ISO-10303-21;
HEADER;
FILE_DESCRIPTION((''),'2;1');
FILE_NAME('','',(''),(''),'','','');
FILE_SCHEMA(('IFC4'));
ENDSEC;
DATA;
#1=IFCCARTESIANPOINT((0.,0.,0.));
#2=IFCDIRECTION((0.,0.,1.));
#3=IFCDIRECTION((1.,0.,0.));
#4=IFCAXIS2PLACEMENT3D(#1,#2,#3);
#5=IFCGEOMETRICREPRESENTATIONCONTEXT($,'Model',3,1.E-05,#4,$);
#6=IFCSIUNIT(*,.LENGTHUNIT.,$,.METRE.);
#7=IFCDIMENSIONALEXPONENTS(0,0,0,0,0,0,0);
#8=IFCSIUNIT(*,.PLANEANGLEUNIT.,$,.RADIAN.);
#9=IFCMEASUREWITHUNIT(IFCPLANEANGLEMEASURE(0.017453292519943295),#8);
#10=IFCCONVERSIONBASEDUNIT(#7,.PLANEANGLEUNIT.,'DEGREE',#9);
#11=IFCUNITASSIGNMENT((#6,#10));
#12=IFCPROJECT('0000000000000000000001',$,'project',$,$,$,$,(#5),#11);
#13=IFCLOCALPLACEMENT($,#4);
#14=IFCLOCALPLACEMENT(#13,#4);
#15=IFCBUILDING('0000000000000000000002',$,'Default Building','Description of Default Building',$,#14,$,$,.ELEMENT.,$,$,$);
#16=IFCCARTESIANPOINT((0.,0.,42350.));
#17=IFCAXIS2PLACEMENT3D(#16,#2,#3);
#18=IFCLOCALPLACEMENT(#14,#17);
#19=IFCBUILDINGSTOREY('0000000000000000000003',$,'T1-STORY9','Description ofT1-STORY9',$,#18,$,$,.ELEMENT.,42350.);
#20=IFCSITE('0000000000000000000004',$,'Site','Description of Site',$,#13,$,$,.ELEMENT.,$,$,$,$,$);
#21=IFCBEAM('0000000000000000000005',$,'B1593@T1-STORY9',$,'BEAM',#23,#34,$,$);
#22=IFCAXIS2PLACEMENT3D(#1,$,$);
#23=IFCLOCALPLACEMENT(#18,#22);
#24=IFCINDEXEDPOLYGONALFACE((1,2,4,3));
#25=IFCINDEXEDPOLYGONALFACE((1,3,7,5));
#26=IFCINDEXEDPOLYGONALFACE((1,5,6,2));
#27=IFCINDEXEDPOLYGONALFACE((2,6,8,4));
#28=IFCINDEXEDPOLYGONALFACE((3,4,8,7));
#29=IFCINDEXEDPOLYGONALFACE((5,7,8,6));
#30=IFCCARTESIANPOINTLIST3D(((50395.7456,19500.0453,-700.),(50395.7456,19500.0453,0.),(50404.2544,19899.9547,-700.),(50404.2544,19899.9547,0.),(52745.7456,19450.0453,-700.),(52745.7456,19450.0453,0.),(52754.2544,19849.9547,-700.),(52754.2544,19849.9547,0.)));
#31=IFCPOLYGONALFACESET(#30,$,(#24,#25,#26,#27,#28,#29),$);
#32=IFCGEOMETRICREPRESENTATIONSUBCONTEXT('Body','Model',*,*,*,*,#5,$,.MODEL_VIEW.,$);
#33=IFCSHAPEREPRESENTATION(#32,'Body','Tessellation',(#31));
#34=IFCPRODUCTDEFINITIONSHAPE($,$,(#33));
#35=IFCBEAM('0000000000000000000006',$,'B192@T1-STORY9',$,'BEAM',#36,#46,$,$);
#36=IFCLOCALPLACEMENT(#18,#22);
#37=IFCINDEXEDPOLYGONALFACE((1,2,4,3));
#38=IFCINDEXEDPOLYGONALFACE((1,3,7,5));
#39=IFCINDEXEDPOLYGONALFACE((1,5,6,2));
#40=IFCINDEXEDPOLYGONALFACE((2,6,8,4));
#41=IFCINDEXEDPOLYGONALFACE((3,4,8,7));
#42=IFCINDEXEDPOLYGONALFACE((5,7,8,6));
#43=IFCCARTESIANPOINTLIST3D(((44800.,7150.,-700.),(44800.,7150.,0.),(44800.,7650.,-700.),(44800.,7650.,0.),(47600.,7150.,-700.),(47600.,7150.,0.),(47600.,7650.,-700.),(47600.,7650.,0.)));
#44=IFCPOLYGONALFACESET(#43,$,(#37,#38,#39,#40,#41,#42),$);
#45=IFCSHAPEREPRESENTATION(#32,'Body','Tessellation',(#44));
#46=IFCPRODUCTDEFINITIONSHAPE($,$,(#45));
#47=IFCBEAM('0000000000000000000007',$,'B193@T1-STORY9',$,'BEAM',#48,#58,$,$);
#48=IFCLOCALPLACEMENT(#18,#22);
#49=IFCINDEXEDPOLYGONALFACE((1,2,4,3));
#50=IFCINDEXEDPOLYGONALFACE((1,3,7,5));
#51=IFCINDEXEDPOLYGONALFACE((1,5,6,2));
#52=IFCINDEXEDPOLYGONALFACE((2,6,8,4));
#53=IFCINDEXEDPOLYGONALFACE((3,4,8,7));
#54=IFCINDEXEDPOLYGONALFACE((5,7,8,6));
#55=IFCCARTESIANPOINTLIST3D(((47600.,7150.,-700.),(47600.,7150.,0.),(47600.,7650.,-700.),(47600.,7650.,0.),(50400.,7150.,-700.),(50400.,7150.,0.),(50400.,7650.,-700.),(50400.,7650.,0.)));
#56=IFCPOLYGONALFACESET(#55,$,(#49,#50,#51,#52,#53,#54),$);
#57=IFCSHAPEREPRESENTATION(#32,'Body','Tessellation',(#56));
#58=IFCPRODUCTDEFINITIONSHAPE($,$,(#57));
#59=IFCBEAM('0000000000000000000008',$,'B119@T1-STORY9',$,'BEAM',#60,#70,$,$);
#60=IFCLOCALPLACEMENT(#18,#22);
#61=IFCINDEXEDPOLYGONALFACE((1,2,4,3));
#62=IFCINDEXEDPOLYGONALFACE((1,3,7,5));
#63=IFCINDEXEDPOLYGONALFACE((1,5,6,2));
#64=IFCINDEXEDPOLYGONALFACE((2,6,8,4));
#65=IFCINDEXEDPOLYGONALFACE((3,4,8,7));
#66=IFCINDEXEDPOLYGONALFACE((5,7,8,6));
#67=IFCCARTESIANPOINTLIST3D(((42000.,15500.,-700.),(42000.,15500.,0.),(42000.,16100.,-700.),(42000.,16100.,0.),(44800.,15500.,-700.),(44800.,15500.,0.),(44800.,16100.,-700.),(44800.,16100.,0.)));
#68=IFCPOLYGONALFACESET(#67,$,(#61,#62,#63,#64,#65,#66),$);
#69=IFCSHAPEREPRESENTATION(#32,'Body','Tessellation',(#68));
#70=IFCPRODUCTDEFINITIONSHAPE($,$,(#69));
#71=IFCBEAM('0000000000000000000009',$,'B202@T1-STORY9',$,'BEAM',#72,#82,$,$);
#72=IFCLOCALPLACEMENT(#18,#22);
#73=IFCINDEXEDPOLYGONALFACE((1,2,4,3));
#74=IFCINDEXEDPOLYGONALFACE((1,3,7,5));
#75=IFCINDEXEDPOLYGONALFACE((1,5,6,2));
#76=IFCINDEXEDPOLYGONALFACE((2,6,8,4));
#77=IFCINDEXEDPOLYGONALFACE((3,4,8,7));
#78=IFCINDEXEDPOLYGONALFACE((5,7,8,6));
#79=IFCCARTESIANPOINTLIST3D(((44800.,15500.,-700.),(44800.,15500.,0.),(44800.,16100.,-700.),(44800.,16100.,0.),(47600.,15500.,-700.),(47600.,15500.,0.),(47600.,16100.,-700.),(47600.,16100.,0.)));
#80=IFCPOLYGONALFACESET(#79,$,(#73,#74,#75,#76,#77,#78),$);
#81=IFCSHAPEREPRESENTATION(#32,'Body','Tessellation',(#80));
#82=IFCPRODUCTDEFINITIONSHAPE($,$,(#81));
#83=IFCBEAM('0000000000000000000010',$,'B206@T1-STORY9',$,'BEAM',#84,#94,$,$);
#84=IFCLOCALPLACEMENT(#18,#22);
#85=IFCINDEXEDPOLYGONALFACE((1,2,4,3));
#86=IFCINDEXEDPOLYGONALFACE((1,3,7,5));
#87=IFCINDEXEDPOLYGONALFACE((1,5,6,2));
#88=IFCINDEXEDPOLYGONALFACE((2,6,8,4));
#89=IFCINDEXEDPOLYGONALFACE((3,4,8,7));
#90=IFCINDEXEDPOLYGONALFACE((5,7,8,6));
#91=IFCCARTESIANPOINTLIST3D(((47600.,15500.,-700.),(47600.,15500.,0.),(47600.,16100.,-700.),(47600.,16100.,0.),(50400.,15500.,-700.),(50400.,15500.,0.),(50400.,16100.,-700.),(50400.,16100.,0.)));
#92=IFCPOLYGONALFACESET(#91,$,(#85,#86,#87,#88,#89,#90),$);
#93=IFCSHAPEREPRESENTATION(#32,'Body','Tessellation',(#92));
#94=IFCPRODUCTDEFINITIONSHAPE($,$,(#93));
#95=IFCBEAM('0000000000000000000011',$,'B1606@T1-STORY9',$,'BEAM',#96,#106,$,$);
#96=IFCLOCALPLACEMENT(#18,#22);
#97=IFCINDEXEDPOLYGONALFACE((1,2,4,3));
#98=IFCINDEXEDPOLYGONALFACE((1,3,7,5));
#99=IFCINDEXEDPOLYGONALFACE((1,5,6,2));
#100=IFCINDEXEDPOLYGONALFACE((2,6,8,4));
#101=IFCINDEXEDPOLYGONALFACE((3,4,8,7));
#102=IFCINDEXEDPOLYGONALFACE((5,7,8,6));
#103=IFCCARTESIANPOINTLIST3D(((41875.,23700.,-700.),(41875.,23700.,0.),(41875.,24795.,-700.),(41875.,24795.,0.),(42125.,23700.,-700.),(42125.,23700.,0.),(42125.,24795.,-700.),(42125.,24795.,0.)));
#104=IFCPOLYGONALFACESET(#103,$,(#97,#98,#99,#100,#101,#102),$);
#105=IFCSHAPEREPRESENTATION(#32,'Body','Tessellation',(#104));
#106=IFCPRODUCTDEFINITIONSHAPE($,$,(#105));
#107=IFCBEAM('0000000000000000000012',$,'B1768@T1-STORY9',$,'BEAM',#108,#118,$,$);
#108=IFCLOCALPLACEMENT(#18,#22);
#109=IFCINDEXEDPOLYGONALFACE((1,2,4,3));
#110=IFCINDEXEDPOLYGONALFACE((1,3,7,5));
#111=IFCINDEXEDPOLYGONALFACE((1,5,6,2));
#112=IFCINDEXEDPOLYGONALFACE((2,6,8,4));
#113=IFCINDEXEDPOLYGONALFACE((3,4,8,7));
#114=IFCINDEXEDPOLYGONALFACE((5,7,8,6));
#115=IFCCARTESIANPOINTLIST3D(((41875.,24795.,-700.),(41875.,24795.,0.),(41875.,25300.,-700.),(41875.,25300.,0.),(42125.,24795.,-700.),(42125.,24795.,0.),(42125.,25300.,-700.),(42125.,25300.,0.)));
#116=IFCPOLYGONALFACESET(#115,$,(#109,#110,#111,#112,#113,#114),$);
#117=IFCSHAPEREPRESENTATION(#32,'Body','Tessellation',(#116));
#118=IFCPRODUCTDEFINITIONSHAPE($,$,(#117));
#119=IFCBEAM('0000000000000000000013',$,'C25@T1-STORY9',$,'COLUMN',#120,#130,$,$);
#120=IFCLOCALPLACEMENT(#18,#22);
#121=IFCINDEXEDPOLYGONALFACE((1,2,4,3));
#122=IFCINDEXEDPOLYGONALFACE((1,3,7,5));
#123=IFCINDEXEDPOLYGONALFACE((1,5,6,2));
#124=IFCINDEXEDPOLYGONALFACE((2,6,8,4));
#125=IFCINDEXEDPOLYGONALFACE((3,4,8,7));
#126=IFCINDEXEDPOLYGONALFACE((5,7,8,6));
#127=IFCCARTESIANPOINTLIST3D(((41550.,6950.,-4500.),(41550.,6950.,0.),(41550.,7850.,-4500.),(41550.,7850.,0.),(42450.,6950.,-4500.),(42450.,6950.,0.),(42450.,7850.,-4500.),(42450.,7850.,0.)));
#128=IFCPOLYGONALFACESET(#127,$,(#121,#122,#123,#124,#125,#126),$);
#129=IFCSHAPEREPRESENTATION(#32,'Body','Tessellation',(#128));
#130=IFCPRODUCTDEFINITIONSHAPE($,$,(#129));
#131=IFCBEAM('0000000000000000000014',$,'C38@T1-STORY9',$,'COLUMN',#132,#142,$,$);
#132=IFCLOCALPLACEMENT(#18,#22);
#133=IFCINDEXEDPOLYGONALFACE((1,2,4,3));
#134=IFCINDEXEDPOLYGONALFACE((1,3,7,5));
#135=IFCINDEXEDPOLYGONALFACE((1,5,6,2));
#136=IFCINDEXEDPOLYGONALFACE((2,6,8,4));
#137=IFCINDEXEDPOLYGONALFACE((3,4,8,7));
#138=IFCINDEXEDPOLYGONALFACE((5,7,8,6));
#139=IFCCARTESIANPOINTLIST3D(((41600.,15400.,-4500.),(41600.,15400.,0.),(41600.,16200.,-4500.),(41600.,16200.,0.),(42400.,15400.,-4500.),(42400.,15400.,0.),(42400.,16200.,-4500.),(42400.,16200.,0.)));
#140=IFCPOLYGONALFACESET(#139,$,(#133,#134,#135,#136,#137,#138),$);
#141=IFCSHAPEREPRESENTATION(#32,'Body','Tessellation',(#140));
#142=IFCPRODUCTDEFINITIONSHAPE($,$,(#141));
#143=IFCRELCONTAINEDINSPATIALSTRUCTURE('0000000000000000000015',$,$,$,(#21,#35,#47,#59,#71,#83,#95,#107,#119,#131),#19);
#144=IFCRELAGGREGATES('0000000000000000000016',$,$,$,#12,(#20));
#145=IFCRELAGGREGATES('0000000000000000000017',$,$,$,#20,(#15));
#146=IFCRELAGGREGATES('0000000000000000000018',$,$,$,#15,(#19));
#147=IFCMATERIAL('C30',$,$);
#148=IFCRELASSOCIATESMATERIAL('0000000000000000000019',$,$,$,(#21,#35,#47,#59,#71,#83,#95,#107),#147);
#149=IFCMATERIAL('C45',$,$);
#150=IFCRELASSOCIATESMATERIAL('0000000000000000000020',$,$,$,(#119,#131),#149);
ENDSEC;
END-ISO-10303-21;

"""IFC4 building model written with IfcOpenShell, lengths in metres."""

from ifc_helpers import new_model, entity, si_unit, converted_unit, frame, origin_with_axes, place, context, subcontext, project, spatial, rectangle, extrude, material, element, save


model = new_model("IFC4")

# Units and contexts
model_context = context("Model", 3, precision=1e-05, world=origin_with_axes())
body_context = subcontext(model_context, "Body", "Model", "MODEL_VIEW")
ifc_project = project(units=[si_unit("LENGTHUNIT", "METRE"), converted_unit("PLANEANGLEUNIT", "DEGREE", entity("IfcPlaneAngleMeasure", 0.017453292519943295), si_unit("PLANEANGLEUNIT", "RADIAN"), dimensions=[0, 0, 0, 0, 0, 0, 0])], contexts=[model_context])

# Site, building, storey
site_placement = place(None, origin_with_axes())
site = spatial("IfcSite", under=ifc_project, at=site_placement, Name="Site", Description="Description of Site", CompositionType="ELEMENT")
building_placement = place(site_placement, origin_with_axes())
building = spatial("IfcBuilding", under=site, at=building_placement, Name="Default Building", Description="Description of Default Building", CompositionType="ELEMENT")
storey_placement = place(building_placement, frame((0.0, 0.0, 42350.0), z_axis=(0.0, 0.0, 1.0), x_axis=(1.0, 0.0, 0.0)))
storey = spatial("IfcBuildingStorey", under=building, at=storey_placement, Name="T1-STORY9", Description="Description ofT1-STORY9", CompositionType="ELEMENT", Elevation=42350.0)

# Beams
ifc_material_1 = material(Name="C30")
beam_1_placement = place(storey_placement, frame((50400.0, 19700.0, -350.0), z_axis=(0.999774, -0.021272, 0.0), x_axis=(0.021272, 0.999774, 0.0)))
element("IfcBeam", 1, at=beam_1_placement, inside=storey, material=ifc_material_1, Name="B1593@T1-STORY9", ObjectType="BEAM", context=body_context, shape_type="SweptSolid", body=[
    extrude(rectangle(XDim=400.0, YDim=700.0), origin_with_axes(), (0.0, 0.0, 1.0), 2350.5319),
])
for number, where, z_axis, x_axis, name in (
    (2, (44800.0, 7400.0, -350.0), (1.0, 0.0, 0.0), (0.0, 1.0, 0.0), "B192@T1-STORY9"),
    (3, (47600.0, 7400.0, -350.0), (1.0, 0.0, 0.0), (0.0, 1.0, 0.0), "B193@T1-STORY9"),
):
    element("IfcBeam", number, at=place(storey_placement, frame(where, z_axis=z_axis, x_axis=x_axis)), inside=storey, material=ifc_material_1, Name=name, ObjectType="BEAM", context=body_context, shape_type="SweptSolid", body=[
        extrude(rectangle(XDim=500.0, YDim=700.0), origin_with_axes(), (0.0, 0.0, 1.0), 2800.0),
    ])
for number, where, z_axis, x_axis, name in (
    (4, (42000.0, 15800.0, -350.0), (1.0, 0.0, 0.0), (0.0, 1.0, 0.0), "B119@T1-STORY9"),
    (5, (44800.0, 15800.0, -350.0), (1.0, 0.0, 0.0), (0.0, 1.0, 0.0), "B202@T1-STORY9"),
    (6, (47600.0, 15800.0, -350.0), (1.0, 0.0, 0.0), (0.0, 1.0, 0.0), "B206@T1-STORY9"),
):
    element("IfcBeam", number, at=place(storey_placement, frame(where, z_axis=z_axis, x_axis=x_axis)), inside=storey, material=ifc_material_1, Name=name, ObjectType="BEAM", context=body_context, shape_type="SweptSolid", body=[
        extrude(rectangle(XDim=600.0, YDim=700.0), origin_with_axes(), (0.0, 0.0, 1.0), 2800.0),
    ])
beam_2_placement = place(storey_placement, frame((42000.0, 23700.0, -350.0), z_axis=(0.0, 1.0, 0.0), x_axis=(-1.0, 0.0, 0.0)))
element("IfcBeam", 7, at=beam_2_placement, inside=storey, material=ifc_material_1, Name="B1606@T1-STORY9", ObjectType="BEAM", context=body_context, shape_type="SweptSolid", body=[
    extrude(rectangle(XDim=250.0, YDim=700.0), origin_with_axes(), (0.0, 0.0, 1.0), 1095.0),
])
beam_3_placement = place(storey_placement, frame((42000.0, 24795.0, -350.0), z_axis=(0.0, 1.0, 0.0), x_axis=(-1.0, 0.0, 0.0)))
element("IfcBeam", 8, at=beam_3_placement, inside=storey, material=ifc_material_1, Name="B1768@T1-STORY9", ObjectType="BEAM", context=body_context, shape_type="SweptSolid", body=[
    extrude(rectangle(XDim=250.0, YDim=700.0), origin_with_axes(), (0.0, 0.0, 1.0), 505.0),
])
ifc_material_2 = material(Name="C45")
beam_4_placement = place(storey_placement, frame((42000.0, 7400.0, -4500.0), z_axis=(0.0, 0.0, 1.0), x_axis=(-1.0, 0.0, 0.0)))
element("IfcBeam", 9, at=beam_4_placement, inside=storey, material=ifc_material_2, Name="C25@T1-STORY9", ObjectType="COLUMN", context=body_context, shape_type="SweptSolid", body=[
    extrude(rectangle(XDim=900.0, YDim=900.0), origin_with_axes(), (0.0, 0.0, 1.0), 4500.0),
])
beam_5_placement = place(storey_placement, frame((42000.0, 15800.0, -4500.0), z_axis=(0.0, 0.0, 1.0), x_axis=(-1.0, 0.0, 0.0)))
element("IfcBeam", 10, at=beam_5_placement, inside=storey, material=ifc_material_2, Name="C38@T1-STORY9", ObjectType="COLUMN", context=body_context, shape_type="SweptSolid", body=[
    extrude(rectangle(XDim=800.0, YDim=800.0), origin_with_axes(), (0.0, 0.0, 1.0), 4500.0),
])

save(model, "model.ifc")
